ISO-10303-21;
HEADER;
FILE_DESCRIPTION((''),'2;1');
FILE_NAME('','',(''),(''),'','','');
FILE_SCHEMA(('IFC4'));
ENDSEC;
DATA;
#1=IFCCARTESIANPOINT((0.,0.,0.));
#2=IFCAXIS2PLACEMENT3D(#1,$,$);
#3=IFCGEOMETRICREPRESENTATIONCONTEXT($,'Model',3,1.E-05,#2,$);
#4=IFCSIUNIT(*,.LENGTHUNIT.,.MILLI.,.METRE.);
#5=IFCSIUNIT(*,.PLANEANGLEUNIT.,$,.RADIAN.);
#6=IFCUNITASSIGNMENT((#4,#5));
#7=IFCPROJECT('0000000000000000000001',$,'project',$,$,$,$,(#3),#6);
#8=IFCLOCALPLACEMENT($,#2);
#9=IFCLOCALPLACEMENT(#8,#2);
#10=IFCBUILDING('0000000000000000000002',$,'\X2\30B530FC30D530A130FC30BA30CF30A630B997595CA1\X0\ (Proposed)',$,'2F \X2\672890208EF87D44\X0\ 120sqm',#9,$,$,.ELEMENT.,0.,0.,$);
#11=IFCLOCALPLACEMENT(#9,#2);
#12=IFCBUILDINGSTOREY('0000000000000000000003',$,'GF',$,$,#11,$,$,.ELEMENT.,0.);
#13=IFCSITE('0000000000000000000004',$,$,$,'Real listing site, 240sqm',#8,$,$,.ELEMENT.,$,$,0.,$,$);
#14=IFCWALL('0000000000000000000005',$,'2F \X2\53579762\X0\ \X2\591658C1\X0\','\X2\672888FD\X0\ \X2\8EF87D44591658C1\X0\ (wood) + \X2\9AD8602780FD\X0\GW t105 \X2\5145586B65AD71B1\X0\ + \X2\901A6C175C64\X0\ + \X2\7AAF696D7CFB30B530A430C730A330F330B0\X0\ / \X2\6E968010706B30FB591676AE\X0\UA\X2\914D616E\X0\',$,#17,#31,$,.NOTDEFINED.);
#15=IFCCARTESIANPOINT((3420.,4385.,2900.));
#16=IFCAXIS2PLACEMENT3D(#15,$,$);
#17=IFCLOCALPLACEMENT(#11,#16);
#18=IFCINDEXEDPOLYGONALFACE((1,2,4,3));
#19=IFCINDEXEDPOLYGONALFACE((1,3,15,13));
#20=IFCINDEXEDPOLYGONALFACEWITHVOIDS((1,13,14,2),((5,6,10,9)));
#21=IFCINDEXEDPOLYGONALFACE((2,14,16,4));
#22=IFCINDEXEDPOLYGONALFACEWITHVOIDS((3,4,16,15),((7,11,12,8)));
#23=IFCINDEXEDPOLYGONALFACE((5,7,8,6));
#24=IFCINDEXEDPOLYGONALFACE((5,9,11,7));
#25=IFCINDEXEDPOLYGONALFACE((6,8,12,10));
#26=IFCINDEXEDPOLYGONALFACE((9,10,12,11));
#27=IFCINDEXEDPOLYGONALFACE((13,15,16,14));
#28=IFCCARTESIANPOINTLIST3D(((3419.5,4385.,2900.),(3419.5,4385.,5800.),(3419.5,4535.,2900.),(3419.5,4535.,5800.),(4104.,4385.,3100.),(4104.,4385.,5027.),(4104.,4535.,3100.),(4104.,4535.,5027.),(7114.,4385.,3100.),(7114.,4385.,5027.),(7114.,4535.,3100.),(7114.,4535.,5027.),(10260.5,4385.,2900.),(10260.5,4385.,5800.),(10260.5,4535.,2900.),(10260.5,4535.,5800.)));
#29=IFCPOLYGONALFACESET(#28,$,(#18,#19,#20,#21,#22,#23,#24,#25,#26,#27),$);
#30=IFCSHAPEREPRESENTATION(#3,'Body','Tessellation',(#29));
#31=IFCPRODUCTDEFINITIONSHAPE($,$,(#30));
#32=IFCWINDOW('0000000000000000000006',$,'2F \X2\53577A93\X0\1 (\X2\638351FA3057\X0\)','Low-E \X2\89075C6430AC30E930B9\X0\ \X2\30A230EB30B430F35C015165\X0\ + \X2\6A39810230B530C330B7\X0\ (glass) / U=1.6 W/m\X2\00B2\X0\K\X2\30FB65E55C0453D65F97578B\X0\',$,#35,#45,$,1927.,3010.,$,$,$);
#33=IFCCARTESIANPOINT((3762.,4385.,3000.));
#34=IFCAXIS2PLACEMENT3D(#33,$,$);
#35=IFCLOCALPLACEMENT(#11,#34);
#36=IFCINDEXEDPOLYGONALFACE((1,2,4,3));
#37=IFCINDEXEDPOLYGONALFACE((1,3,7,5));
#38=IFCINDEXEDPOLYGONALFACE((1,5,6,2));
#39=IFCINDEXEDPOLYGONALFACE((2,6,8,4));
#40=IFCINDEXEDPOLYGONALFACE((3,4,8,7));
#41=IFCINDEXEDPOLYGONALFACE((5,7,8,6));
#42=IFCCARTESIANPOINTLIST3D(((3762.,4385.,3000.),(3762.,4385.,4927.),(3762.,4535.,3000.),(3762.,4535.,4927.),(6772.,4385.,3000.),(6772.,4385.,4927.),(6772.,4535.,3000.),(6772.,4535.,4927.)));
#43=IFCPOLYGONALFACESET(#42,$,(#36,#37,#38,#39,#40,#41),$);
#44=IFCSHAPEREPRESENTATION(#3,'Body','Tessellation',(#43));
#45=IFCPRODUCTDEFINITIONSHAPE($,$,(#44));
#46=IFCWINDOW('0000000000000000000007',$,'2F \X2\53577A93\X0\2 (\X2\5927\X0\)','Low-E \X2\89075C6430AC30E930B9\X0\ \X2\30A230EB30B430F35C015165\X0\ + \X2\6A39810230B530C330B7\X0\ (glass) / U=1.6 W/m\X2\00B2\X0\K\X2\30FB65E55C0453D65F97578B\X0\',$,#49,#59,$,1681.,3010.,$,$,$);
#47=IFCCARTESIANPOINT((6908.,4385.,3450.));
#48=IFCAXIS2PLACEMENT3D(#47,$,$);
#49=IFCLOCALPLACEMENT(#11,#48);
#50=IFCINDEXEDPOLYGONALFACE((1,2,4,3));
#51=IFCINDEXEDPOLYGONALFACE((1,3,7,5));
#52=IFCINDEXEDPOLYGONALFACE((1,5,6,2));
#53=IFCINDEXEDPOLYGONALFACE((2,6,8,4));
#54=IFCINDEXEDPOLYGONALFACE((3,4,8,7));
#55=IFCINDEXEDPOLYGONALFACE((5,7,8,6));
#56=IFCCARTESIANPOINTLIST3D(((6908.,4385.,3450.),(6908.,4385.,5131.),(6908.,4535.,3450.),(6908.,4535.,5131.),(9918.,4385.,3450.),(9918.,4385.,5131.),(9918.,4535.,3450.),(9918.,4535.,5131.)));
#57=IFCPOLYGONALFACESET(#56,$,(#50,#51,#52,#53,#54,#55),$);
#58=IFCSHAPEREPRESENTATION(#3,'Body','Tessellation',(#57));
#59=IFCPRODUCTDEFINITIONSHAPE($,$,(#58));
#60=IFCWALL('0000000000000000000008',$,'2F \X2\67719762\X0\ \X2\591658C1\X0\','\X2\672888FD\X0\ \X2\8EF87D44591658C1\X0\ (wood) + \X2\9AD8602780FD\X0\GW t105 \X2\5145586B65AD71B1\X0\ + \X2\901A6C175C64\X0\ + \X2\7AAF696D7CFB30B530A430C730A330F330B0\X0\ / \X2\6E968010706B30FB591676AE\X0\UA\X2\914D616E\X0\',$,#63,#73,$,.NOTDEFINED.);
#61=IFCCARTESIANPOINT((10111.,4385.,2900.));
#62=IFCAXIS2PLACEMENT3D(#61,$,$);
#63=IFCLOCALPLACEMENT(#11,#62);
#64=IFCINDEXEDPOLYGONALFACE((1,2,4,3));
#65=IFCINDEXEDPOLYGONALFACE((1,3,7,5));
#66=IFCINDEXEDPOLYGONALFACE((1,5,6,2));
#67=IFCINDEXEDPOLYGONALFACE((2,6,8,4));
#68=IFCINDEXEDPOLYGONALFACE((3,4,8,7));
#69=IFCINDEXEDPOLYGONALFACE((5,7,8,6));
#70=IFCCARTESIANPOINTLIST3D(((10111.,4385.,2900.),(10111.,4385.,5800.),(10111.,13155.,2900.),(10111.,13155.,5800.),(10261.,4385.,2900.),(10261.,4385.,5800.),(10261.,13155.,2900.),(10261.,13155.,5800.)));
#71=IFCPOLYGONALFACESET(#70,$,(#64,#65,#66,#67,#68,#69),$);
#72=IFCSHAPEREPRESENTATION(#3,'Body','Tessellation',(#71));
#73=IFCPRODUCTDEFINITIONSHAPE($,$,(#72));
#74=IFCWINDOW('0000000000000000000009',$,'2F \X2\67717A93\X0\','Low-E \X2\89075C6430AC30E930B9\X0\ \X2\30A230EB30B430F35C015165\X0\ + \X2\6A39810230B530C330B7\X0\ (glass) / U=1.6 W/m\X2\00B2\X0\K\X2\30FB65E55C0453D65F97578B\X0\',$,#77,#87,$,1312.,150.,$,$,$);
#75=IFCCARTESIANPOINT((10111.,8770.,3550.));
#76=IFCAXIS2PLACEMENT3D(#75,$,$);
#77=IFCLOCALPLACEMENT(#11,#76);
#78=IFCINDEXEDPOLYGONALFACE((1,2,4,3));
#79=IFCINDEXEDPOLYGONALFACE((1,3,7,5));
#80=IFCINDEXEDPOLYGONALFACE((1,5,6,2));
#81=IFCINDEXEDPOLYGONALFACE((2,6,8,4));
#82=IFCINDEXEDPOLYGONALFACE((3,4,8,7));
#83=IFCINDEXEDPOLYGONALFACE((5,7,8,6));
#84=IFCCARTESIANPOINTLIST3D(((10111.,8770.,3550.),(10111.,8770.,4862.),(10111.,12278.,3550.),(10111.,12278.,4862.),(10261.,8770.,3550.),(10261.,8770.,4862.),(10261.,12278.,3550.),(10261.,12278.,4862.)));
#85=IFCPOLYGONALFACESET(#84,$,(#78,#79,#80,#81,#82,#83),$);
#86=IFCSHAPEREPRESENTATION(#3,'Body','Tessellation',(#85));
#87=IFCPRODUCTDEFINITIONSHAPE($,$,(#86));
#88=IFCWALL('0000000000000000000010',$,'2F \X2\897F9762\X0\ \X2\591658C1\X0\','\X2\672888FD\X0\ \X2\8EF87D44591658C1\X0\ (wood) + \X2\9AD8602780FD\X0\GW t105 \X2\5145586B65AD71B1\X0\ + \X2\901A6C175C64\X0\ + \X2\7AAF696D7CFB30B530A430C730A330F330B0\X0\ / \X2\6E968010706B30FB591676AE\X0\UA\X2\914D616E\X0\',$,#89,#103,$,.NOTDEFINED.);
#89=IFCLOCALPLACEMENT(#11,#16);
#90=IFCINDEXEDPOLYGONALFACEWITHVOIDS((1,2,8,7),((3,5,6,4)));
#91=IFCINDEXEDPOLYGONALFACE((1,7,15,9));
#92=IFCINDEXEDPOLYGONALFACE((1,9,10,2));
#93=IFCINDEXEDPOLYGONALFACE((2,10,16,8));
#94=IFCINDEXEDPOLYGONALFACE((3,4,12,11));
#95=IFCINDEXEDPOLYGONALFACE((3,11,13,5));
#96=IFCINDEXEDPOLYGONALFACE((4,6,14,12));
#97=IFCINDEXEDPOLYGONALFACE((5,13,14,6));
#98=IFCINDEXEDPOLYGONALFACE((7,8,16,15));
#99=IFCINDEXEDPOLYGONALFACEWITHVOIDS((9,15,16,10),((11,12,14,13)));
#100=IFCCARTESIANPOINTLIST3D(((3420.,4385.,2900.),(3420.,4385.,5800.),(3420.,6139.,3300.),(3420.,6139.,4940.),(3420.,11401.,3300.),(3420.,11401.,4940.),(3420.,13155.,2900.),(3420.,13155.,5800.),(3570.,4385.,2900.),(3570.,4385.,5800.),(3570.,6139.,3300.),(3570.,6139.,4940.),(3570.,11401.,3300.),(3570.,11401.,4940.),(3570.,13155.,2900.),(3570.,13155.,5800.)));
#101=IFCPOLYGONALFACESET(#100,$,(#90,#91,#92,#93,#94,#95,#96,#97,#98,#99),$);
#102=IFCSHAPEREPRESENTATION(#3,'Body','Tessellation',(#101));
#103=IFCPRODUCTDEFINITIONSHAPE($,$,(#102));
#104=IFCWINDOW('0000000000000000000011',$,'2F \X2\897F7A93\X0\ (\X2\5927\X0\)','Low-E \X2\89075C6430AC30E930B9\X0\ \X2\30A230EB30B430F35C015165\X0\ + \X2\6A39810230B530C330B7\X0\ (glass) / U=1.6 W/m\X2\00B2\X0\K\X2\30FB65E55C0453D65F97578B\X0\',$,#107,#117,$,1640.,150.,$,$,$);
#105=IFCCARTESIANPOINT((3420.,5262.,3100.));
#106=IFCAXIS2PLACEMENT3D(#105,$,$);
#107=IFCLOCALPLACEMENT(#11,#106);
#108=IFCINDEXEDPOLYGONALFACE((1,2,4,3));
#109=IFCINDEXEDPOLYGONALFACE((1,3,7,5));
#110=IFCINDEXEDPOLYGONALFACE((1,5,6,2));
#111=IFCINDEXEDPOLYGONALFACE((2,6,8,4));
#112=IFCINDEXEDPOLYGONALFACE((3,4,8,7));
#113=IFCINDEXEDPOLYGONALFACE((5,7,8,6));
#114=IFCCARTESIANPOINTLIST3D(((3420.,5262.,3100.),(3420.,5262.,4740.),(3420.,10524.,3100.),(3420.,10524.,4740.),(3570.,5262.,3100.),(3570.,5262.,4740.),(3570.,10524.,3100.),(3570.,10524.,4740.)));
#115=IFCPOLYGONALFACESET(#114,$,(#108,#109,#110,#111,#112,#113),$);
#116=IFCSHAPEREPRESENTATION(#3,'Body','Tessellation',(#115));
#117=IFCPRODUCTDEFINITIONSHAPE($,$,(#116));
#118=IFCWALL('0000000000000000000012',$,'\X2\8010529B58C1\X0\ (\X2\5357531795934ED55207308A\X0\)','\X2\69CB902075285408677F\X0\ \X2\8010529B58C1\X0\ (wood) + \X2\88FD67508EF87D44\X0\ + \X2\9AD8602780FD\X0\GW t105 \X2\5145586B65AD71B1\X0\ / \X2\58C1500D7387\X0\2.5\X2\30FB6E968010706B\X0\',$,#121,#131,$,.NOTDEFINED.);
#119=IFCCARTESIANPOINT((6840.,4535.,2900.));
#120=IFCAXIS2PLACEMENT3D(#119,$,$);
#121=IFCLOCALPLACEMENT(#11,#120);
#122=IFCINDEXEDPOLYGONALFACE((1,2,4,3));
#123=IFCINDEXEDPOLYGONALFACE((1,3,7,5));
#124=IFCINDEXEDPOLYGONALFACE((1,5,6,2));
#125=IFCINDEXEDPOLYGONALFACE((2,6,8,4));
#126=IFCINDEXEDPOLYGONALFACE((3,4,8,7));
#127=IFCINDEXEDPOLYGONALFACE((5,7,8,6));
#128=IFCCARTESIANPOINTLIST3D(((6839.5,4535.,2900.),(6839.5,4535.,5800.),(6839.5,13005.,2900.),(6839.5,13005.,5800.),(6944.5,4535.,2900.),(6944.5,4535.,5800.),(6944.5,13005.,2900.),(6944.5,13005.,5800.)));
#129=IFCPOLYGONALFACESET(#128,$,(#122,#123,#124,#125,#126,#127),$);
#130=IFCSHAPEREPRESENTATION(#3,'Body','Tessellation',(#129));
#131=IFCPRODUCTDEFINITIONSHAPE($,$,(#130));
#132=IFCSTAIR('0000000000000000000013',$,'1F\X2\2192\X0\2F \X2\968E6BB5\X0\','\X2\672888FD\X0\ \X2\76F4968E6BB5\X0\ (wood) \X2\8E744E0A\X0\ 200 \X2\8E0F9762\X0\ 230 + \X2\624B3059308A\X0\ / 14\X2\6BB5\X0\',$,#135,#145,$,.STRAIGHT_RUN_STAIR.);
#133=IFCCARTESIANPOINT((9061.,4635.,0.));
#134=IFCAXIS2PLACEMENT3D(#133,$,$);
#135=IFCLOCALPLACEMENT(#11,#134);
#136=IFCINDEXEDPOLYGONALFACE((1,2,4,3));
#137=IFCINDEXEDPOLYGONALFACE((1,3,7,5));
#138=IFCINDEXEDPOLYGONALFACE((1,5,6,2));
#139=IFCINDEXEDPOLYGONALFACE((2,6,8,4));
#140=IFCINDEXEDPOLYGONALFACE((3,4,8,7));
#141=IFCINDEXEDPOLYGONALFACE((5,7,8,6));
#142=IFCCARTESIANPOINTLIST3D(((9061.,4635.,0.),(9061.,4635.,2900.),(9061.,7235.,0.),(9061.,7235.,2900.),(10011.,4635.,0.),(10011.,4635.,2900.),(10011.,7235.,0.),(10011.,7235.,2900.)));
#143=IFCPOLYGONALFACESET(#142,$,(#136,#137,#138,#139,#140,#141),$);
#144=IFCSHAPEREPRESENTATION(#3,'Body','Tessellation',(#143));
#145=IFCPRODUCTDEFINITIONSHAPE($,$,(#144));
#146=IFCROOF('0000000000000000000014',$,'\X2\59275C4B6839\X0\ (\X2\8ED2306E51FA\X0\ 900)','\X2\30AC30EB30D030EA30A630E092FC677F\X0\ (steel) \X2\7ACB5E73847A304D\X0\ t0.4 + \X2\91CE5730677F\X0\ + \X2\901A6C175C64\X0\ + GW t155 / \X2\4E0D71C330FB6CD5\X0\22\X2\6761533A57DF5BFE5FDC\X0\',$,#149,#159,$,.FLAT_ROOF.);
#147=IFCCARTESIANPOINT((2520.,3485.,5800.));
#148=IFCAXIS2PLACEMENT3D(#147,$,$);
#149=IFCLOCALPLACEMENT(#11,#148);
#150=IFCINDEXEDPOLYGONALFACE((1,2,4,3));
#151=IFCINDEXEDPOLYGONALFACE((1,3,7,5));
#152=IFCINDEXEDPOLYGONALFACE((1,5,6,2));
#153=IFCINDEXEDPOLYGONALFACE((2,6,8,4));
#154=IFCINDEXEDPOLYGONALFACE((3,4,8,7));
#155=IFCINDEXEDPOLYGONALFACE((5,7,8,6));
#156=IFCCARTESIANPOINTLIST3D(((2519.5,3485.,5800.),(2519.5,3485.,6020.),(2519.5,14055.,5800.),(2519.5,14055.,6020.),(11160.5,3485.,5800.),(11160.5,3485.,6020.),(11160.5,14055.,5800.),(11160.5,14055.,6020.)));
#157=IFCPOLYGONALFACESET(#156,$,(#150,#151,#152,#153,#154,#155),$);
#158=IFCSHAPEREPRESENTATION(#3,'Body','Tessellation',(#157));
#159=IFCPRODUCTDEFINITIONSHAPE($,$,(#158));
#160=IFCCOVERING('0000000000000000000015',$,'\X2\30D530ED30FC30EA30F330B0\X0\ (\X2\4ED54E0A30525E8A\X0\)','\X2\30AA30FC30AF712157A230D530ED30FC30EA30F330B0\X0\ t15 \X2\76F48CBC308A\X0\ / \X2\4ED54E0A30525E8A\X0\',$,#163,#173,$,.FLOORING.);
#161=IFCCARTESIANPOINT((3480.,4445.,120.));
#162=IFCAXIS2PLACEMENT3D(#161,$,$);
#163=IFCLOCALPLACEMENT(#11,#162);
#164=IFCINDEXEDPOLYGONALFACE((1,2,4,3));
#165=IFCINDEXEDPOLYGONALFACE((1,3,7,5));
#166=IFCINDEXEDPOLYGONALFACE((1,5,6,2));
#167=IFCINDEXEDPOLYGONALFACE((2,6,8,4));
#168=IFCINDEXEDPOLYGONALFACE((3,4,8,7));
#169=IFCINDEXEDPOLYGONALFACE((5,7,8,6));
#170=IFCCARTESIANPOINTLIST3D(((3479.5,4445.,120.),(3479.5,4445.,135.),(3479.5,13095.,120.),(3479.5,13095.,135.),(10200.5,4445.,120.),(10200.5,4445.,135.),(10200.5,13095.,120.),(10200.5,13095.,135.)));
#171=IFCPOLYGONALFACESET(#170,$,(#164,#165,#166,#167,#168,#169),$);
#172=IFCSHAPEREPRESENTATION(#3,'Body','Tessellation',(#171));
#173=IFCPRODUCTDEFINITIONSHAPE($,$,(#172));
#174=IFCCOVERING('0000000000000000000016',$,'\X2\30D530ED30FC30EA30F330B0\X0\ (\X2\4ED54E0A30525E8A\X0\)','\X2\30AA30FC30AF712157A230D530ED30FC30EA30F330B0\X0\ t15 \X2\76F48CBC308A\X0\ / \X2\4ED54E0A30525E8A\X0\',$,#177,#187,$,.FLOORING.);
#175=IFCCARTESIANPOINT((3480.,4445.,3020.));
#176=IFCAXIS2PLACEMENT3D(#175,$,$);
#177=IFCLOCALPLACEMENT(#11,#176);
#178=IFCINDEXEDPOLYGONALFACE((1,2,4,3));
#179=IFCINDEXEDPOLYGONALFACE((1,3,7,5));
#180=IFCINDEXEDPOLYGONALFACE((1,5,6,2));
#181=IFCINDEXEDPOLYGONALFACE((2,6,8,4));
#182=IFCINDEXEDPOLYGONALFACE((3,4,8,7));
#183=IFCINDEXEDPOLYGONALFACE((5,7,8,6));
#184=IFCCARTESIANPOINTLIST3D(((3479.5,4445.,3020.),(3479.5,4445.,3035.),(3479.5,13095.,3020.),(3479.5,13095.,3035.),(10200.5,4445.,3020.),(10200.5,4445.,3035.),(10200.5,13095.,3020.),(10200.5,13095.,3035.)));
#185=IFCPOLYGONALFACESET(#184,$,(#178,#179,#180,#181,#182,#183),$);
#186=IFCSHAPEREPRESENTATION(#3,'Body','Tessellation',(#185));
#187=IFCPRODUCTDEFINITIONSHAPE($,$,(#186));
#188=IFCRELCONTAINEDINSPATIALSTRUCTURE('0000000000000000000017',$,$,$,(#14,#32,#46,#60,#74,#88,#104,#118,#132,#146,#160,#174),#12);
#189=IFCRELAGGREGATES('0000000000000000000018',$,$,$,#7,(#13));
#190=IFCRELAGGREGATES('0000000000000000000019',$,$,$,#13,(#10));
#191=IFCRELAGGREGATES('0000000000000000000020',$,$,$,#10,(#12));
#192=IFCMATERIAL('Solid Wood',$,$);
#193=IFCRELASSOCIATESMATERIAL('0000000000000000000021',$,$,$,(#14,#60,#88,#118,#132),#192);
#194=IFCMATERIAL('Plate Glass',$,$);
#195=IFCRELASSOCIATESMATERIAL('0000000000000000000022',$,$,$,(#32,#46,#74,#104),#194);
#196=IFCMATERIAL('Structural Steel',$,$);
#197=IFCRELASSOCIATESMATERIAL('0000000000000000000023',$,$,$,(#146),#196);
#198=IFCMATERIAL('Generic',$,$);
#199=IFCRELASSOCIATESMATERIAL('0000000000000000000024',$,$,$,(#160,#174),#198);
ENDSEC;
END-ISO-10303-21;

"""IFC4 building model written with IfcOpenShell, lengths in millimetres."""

from ifc_helpers import new_model, si_unit, frame, frame_2d, origin, place, context, project, spatial, rectangle, extrude, material, element, fill, save


model = new_model("IFC4")

# Units and contexts
model_context = context("Model", 3, precision=1e-05, world=origin())
ifc_project = project(units=[si_unit("LENGTHUNIT", "METRE", prefix="MILLI"), si_unit("PLANEANGLEUNIT", "RADIAN")], contexts=[model_context])

# Site, building, storey
site_placement = place(None, origin())
site = spatial("IfcSite", under=ifc_project, at=site_placement, ObjectType="Real listing site, 240sqm", CompositionType="ELEMENT", RefElevation=0.0)
building_placement = place(site_placement, origin())
building = spatial("IfcBuilding", under=site, at=building_placement, Name="サーファーズハウス静岡 (Proposed)", ObjectType="2F 木造軸組 120sqm", CompositionType="ELEMENT", ElevationOfRefHeight=0.0, ElevationOfTerrain=0.0)
storey_placement = place(building_placement, origin())
storey = spatial("IfcBuildingStorey", under=building, at=storey_placement, Name="GF", CompositionType="ELEMENT", Elevation=0.0)

# Shared definitions
ifc_material_1 = material(Name="Solid Wood")

# Shared definitions
ifc_material_2 = material(Name="Plate Glass")

# Wall, openings, windows
wall_1_placement = place(storey_placement, frame((3420.0, 4385.0, 2900.0)))
wall_1 = element("IfcWall", 1, at=wall_1_placement, inside=storey, material=ifc_material_1, Name="2F 南面 外壁", Description="木製 軸組外壁 (wood) + 高性能GW t105 充填断熱 + 通気層 + 窯業系サイディング / 準耐火・外皮UA配慮", PredefinedType="NOTDEFINED", context=model_context, shape_type="SweptSolid", body=[
    extrude(rectangle(XDim=6841.0, YDim=150.0, at=frame_2d((3420.0, 75.0))), frame((3420.0, 4385.0, 2900.0)), (0.0, 0.0, 1.0), 2900.0),
])
opening_1_placement = place(storey_placement, frame((3762.0, 4385.0, 3000.0)))
opening_1 = element("IfcOpeningElement", 2, at=opening_1_placement, cuts=wall_1, PredefinedType="NOTDEFINED", context=model_context, shape_type="SweptSolid", body=[
    extrude(rectangle(XDim=3010.0, YDim=150.0, at=frame_2d((1505.0, 75.0))), frame((3762.0, 4385.0, 3000.0)), (0.0, 0.0, 1.0), 1927.0),
])
opening_2_placement = place(storey_placement, frame((6908.0, 4385.0, 3450.0)))
opening_2 = element("IfcOpeningElement", 3, at=opening_2_placement, cuts=wall_1, PredefinedType="NOTDEFINED", context=model_context, shape_type="SweptSolid", body=[
    extrude(rectangle(XDim=3010.0, YDim=150.0, at=frame_2d((1505.0, 75.0))), frame((6908.0, 4385.0, 3450.0)), (0.0, 0.0, 1.0), 1681.0),
])
window_1_placement = place(storey_placement, frame((3762.0, 4385.0, 3000.0)))
window_1 = element("IfcWindow", 4, at=window_1_placement, inside=storey, material=ifc_material_2, Name="2F 南窓1 (掃出し)", Description="Low-E 複層ガラス アルゴン封入 + 樹脂サッシ (glass) / U=1.6 W/m²K・日射取得型", OverallHeight=1927.0, OverallWidth=3010.0, context=model_context, shape_type="SweptSolid", body=[
    extrude(rectangle(XDim=3010.0, YDim=150.0, at=frame_2d((1505.0, 75.0))), frame((3762.0, 4385.0, 3000.0)), (0.0, 0.0, 1.0), 1927.0),
])
fill(opening_1, window_1)
window_2_placement = place(storey_placement, frame((6908.0, 4385.0, 3450.0)))
window_2 = element("IfcWindow", 5, at=window_2_placement, inside=storey, material=ifc_material_2, Name="2F 南窓2 (大)", Description="Low-E 複層ガラス アルゴン封入 + 樹脂サッシ (glass) / U=1.6 W/m²K・日射取得型", OverallHeight=1681.0, OverallWidth=3010.0, context=model_context, shape_type="SweptSolid", body=[
    extrude(rectangle(XDim=3010.0, YDim=150.0, at=frame_2d((1505.0, 75.0))), frame((6908.0, 4385.0, 3450.0)), (0.0, 0.0, 1.0), 1681.0),
])
fill(opening_2, window_2)

# Walls, openings, windows
wall_2_placement = place(storey_placement, frame((10111.0, 4385.0, 2900.0)))
wall_2 = element("IfcWall", 6, at=wall_2_placement, inside=storey, material=ifc_material_1, Name="2F 東面 外壁", Description="木製 軸組外壁 (wood) + 高性能GW t105 充填断熱 + 通気層 + 窯業系サイディング / 準耐火・外皮UA配慮", PredefinedType="NOTDEFINED", context=model_context, shape_type="SweptSolid", body=[
    extrude(rectangle(XDim=150.0, YDim=8770.0, at=frame_2d((75.0, 4385.0))), frame((10111.0, 4385.0, 2900.0)), (0.0, 0.0, 1.0), 2900.0),
])
opening_3_placement = place(storey_placement, frame((10111.0, 8770.0, 3550.0)))
opening_3 = element("IfcOpeningElement", 7, at=opening_3_placement, cuts=wall_2, PredefinedType="NOTDEFINED", context=model_context, shape_type="SweptSolid", body=[
    extrude(rectangle(XDim=150.0, YDim=3508.0, at=frame_2d((75.0, 1754.0))), frame((10111.0, 8770.0, 3550.0)), (0.0, 0.0, 1.0), 1312.0),
])
window_3_placement = place(storey_placement, frame((10111.0, 8770.0, 3550.0)))
window_3 = element("IfcWindow", 8, at=window_3_placement, inside=storey, material=ifc_material_2, Name="2F 東窓", Description="Low-E 複層ガラス アルゴン封入 + 樹脂サッシ (glass) / U=1.6 W/m²K・日射取得型", OverallHeight=1312.0, OverallWidth=150.0, context=model_context, shape_type="SweptSolid", body=[
    extrude(rectangle(XDim=150.0, YDim=3508.0, at=frame_2d((75.0, 1754.0))), frame((10111.0, 8770.0, 3550.0)), (0.0, 0.0, 1.0), 1312.0),
])
fill(opening_3, window_3)
wall_3_placement = place(storey_placement, frame((3420.0, 4385.0, 2900.0)))
wall_3 = element("IfcWall", 9, at=wall_3_placement, inside=storey, material=ifc_material_1, Name="2F 西面 外壁", Description="木製 軸組外壁 (wood) + 高性能GW t105 充填断熱 + 通気層 + 窯業系サイディング / 準耐火・外皮UA配慮", PredefinedType="NOTDEFINED", context=model_context, shape_type="SweptSolid", body=[
    extrude(rectangle(XDim=150.0, YDim=8770.0, at=frame_2d((75.0, 4385.0))), frame((3420.0, 4385.0, 2900.0)), (0.0, 0.0, 1.0), 2900.0),
])
opening_4_placement = place(storey_placement, frame((3420.0, 5262.0, 3100.0)))
opening_4 = element("IfcOpeningElement", 10, at=opening_4_placement, cuts=wall_3, PredefinedType="NOTDEFINED", context=model_context, shape_type="SweptSolid", body=[
    extrude(rectangle(XDim=150.0, YDim=5262.0, at=frame_2d((75.0, 2631.0))), frame((3420.0, 5262.0, 3100.0)), (0.0, 0.0, 1.0), 1640.0),
])
window_4_placement = place(storey_placement, frame((3420.0, 5262.0, 3100.0)))
window_4 = element("IfcWindow", 11, at=window_4_placement, inside=storey, material=ifc_material_2, Name="2F 西窓 (大)", Description="Low-E 複層ガラス アルゴン封入 + 樹脂サッシ (glass) / U=1.6 W/m²K・日射取得型", OverallHeight=1640.0, OverallWidth=150.0, context=model_context, shape_type="SweptSolid", body=[
    extrude(rectangle(XDim=150.0, YDim=5262.0, at=frame_2d((75.0, 2631.0))), frame((3420.0, 5262.0, 3100.0)), (0.0, 0.0, 1.0), 1640.0),
])
fill(opening_4, window_4)

# Wall
wall_4_placement = place(storey_placement, frame((6840.0, 4535.0, 2900.0)))
element("IfcWall", 12, at=wall_4_placement, inside=storey, material=ifc_material_1, Name="耐力壁 (南北間仕切り)", Description="構造用合板 耐力壁 (wood) + 製材軸組 + 高性能GW t105 充填断熱 / 壁倍率2.5・準耐火", PredefinedType="NOTDEFINED", context=model_context, shape_type="SweptSolid", body=[
    extrude(rectangle(XDim=105.0, YDim=8470.0, at=frame_2d((52.0, 4235.0))), frame((6840.0, 4535.0, 2900.0)), (0.0, 0.0, 1.0), 2900.0),
])

# Stair
stair_placement = place(storey_placement, frame((9061.0, 4635.0, 0.0)))
element("IfcStair", 13, at=stair_placement, inside=storey, material=ifc_material_1, Name="1F→2F 階段", Description="木製 直階段 (wood) 蹴上 200 踏面 230 + 手すり / 14段", PredefinedType="STRAIGHT_RUN_STAIR", context=model_context, shape_type="SweptSolid", body=[
    extrude(rectangle(XDim=950.0, YDim=2600.0, at=frame_2d((475.0, 1300.0))), frame((9061.0, 4635.0, 0.0)), (0.0, 0.0, 1.0), 2900.0),
])

# Roof
ifc_material_3 = material(Name="Structural Steel")
roof_placement = place(storey_placement, frame((2520.0, 3485.0, 5800.0)))
element("IfcRoof", 14, at=roof_placement, inside=storey, material=ifc_material_3, Name="大屋根 (軒の出 900)", Description="ガルバリウム鋼板 (steel) 立平葺き t0.4 + 野地板 + 通気層 + GW t155 / 不燃・法22条区域対応", PredefinedType="FLAT_ROOF", context=model_context, shape_type="SweptSolid", body=[
    extrude(rectangle(XDim=8641.0, YDim=10570.0, at=frame_2d((4320.0, 5285.0))), frame((2520.0, 3485.0, 5800.0)), (0.0, 0.0, 1.0), 220.0),
])

# Coverings
ifc_material_4 = material(Name="Generic")
covering_1_placement = place(storey_placement, frame((3480.0, 4445.0, 120.0)))
element("IfcCovering", 15, at=covering_1_placement, inside=storey, material=ifc_material_4, Name="フローリング (仕上げ床)", Description="オーク無垢フローリング t15 直貼り / 仕上げ床", PredefinedType="FLOORING", context=model_context, shape_type="SweptSolid", body=[
    extrude(rectangle(XDim=6721.0, YDim=8650.0, at=frame_2d((3360.0, 4325.0))), frame((3480.0, 4445.0, 120.0)), (0.0, 0.0, 1.0), 15.0),
])
covering_2_placement = place(storey_placement, frame((3480.0, 4445.0, 3020.0)))
element("IfcCovering", 16, at=covering_2_placement, inside=storey, material=ifc_material_4, Name="フローリング (仕上げ床)", Description="オーク無垢フローリング t15 直貼り / 仕上げ床", PredefinedType="FLOORING", context=model_context, shape_type="SweptSolid", body=[
    extrude(rectangle(XDim=6721.0, YDim=8650.0, at=frame_2d((3360.0, 4325.0))), frame((3480.0, 4445.0, 3020.0)), (0.0, 0.0, 1.0), 15.0),
])

save(model, "model.ifc")
